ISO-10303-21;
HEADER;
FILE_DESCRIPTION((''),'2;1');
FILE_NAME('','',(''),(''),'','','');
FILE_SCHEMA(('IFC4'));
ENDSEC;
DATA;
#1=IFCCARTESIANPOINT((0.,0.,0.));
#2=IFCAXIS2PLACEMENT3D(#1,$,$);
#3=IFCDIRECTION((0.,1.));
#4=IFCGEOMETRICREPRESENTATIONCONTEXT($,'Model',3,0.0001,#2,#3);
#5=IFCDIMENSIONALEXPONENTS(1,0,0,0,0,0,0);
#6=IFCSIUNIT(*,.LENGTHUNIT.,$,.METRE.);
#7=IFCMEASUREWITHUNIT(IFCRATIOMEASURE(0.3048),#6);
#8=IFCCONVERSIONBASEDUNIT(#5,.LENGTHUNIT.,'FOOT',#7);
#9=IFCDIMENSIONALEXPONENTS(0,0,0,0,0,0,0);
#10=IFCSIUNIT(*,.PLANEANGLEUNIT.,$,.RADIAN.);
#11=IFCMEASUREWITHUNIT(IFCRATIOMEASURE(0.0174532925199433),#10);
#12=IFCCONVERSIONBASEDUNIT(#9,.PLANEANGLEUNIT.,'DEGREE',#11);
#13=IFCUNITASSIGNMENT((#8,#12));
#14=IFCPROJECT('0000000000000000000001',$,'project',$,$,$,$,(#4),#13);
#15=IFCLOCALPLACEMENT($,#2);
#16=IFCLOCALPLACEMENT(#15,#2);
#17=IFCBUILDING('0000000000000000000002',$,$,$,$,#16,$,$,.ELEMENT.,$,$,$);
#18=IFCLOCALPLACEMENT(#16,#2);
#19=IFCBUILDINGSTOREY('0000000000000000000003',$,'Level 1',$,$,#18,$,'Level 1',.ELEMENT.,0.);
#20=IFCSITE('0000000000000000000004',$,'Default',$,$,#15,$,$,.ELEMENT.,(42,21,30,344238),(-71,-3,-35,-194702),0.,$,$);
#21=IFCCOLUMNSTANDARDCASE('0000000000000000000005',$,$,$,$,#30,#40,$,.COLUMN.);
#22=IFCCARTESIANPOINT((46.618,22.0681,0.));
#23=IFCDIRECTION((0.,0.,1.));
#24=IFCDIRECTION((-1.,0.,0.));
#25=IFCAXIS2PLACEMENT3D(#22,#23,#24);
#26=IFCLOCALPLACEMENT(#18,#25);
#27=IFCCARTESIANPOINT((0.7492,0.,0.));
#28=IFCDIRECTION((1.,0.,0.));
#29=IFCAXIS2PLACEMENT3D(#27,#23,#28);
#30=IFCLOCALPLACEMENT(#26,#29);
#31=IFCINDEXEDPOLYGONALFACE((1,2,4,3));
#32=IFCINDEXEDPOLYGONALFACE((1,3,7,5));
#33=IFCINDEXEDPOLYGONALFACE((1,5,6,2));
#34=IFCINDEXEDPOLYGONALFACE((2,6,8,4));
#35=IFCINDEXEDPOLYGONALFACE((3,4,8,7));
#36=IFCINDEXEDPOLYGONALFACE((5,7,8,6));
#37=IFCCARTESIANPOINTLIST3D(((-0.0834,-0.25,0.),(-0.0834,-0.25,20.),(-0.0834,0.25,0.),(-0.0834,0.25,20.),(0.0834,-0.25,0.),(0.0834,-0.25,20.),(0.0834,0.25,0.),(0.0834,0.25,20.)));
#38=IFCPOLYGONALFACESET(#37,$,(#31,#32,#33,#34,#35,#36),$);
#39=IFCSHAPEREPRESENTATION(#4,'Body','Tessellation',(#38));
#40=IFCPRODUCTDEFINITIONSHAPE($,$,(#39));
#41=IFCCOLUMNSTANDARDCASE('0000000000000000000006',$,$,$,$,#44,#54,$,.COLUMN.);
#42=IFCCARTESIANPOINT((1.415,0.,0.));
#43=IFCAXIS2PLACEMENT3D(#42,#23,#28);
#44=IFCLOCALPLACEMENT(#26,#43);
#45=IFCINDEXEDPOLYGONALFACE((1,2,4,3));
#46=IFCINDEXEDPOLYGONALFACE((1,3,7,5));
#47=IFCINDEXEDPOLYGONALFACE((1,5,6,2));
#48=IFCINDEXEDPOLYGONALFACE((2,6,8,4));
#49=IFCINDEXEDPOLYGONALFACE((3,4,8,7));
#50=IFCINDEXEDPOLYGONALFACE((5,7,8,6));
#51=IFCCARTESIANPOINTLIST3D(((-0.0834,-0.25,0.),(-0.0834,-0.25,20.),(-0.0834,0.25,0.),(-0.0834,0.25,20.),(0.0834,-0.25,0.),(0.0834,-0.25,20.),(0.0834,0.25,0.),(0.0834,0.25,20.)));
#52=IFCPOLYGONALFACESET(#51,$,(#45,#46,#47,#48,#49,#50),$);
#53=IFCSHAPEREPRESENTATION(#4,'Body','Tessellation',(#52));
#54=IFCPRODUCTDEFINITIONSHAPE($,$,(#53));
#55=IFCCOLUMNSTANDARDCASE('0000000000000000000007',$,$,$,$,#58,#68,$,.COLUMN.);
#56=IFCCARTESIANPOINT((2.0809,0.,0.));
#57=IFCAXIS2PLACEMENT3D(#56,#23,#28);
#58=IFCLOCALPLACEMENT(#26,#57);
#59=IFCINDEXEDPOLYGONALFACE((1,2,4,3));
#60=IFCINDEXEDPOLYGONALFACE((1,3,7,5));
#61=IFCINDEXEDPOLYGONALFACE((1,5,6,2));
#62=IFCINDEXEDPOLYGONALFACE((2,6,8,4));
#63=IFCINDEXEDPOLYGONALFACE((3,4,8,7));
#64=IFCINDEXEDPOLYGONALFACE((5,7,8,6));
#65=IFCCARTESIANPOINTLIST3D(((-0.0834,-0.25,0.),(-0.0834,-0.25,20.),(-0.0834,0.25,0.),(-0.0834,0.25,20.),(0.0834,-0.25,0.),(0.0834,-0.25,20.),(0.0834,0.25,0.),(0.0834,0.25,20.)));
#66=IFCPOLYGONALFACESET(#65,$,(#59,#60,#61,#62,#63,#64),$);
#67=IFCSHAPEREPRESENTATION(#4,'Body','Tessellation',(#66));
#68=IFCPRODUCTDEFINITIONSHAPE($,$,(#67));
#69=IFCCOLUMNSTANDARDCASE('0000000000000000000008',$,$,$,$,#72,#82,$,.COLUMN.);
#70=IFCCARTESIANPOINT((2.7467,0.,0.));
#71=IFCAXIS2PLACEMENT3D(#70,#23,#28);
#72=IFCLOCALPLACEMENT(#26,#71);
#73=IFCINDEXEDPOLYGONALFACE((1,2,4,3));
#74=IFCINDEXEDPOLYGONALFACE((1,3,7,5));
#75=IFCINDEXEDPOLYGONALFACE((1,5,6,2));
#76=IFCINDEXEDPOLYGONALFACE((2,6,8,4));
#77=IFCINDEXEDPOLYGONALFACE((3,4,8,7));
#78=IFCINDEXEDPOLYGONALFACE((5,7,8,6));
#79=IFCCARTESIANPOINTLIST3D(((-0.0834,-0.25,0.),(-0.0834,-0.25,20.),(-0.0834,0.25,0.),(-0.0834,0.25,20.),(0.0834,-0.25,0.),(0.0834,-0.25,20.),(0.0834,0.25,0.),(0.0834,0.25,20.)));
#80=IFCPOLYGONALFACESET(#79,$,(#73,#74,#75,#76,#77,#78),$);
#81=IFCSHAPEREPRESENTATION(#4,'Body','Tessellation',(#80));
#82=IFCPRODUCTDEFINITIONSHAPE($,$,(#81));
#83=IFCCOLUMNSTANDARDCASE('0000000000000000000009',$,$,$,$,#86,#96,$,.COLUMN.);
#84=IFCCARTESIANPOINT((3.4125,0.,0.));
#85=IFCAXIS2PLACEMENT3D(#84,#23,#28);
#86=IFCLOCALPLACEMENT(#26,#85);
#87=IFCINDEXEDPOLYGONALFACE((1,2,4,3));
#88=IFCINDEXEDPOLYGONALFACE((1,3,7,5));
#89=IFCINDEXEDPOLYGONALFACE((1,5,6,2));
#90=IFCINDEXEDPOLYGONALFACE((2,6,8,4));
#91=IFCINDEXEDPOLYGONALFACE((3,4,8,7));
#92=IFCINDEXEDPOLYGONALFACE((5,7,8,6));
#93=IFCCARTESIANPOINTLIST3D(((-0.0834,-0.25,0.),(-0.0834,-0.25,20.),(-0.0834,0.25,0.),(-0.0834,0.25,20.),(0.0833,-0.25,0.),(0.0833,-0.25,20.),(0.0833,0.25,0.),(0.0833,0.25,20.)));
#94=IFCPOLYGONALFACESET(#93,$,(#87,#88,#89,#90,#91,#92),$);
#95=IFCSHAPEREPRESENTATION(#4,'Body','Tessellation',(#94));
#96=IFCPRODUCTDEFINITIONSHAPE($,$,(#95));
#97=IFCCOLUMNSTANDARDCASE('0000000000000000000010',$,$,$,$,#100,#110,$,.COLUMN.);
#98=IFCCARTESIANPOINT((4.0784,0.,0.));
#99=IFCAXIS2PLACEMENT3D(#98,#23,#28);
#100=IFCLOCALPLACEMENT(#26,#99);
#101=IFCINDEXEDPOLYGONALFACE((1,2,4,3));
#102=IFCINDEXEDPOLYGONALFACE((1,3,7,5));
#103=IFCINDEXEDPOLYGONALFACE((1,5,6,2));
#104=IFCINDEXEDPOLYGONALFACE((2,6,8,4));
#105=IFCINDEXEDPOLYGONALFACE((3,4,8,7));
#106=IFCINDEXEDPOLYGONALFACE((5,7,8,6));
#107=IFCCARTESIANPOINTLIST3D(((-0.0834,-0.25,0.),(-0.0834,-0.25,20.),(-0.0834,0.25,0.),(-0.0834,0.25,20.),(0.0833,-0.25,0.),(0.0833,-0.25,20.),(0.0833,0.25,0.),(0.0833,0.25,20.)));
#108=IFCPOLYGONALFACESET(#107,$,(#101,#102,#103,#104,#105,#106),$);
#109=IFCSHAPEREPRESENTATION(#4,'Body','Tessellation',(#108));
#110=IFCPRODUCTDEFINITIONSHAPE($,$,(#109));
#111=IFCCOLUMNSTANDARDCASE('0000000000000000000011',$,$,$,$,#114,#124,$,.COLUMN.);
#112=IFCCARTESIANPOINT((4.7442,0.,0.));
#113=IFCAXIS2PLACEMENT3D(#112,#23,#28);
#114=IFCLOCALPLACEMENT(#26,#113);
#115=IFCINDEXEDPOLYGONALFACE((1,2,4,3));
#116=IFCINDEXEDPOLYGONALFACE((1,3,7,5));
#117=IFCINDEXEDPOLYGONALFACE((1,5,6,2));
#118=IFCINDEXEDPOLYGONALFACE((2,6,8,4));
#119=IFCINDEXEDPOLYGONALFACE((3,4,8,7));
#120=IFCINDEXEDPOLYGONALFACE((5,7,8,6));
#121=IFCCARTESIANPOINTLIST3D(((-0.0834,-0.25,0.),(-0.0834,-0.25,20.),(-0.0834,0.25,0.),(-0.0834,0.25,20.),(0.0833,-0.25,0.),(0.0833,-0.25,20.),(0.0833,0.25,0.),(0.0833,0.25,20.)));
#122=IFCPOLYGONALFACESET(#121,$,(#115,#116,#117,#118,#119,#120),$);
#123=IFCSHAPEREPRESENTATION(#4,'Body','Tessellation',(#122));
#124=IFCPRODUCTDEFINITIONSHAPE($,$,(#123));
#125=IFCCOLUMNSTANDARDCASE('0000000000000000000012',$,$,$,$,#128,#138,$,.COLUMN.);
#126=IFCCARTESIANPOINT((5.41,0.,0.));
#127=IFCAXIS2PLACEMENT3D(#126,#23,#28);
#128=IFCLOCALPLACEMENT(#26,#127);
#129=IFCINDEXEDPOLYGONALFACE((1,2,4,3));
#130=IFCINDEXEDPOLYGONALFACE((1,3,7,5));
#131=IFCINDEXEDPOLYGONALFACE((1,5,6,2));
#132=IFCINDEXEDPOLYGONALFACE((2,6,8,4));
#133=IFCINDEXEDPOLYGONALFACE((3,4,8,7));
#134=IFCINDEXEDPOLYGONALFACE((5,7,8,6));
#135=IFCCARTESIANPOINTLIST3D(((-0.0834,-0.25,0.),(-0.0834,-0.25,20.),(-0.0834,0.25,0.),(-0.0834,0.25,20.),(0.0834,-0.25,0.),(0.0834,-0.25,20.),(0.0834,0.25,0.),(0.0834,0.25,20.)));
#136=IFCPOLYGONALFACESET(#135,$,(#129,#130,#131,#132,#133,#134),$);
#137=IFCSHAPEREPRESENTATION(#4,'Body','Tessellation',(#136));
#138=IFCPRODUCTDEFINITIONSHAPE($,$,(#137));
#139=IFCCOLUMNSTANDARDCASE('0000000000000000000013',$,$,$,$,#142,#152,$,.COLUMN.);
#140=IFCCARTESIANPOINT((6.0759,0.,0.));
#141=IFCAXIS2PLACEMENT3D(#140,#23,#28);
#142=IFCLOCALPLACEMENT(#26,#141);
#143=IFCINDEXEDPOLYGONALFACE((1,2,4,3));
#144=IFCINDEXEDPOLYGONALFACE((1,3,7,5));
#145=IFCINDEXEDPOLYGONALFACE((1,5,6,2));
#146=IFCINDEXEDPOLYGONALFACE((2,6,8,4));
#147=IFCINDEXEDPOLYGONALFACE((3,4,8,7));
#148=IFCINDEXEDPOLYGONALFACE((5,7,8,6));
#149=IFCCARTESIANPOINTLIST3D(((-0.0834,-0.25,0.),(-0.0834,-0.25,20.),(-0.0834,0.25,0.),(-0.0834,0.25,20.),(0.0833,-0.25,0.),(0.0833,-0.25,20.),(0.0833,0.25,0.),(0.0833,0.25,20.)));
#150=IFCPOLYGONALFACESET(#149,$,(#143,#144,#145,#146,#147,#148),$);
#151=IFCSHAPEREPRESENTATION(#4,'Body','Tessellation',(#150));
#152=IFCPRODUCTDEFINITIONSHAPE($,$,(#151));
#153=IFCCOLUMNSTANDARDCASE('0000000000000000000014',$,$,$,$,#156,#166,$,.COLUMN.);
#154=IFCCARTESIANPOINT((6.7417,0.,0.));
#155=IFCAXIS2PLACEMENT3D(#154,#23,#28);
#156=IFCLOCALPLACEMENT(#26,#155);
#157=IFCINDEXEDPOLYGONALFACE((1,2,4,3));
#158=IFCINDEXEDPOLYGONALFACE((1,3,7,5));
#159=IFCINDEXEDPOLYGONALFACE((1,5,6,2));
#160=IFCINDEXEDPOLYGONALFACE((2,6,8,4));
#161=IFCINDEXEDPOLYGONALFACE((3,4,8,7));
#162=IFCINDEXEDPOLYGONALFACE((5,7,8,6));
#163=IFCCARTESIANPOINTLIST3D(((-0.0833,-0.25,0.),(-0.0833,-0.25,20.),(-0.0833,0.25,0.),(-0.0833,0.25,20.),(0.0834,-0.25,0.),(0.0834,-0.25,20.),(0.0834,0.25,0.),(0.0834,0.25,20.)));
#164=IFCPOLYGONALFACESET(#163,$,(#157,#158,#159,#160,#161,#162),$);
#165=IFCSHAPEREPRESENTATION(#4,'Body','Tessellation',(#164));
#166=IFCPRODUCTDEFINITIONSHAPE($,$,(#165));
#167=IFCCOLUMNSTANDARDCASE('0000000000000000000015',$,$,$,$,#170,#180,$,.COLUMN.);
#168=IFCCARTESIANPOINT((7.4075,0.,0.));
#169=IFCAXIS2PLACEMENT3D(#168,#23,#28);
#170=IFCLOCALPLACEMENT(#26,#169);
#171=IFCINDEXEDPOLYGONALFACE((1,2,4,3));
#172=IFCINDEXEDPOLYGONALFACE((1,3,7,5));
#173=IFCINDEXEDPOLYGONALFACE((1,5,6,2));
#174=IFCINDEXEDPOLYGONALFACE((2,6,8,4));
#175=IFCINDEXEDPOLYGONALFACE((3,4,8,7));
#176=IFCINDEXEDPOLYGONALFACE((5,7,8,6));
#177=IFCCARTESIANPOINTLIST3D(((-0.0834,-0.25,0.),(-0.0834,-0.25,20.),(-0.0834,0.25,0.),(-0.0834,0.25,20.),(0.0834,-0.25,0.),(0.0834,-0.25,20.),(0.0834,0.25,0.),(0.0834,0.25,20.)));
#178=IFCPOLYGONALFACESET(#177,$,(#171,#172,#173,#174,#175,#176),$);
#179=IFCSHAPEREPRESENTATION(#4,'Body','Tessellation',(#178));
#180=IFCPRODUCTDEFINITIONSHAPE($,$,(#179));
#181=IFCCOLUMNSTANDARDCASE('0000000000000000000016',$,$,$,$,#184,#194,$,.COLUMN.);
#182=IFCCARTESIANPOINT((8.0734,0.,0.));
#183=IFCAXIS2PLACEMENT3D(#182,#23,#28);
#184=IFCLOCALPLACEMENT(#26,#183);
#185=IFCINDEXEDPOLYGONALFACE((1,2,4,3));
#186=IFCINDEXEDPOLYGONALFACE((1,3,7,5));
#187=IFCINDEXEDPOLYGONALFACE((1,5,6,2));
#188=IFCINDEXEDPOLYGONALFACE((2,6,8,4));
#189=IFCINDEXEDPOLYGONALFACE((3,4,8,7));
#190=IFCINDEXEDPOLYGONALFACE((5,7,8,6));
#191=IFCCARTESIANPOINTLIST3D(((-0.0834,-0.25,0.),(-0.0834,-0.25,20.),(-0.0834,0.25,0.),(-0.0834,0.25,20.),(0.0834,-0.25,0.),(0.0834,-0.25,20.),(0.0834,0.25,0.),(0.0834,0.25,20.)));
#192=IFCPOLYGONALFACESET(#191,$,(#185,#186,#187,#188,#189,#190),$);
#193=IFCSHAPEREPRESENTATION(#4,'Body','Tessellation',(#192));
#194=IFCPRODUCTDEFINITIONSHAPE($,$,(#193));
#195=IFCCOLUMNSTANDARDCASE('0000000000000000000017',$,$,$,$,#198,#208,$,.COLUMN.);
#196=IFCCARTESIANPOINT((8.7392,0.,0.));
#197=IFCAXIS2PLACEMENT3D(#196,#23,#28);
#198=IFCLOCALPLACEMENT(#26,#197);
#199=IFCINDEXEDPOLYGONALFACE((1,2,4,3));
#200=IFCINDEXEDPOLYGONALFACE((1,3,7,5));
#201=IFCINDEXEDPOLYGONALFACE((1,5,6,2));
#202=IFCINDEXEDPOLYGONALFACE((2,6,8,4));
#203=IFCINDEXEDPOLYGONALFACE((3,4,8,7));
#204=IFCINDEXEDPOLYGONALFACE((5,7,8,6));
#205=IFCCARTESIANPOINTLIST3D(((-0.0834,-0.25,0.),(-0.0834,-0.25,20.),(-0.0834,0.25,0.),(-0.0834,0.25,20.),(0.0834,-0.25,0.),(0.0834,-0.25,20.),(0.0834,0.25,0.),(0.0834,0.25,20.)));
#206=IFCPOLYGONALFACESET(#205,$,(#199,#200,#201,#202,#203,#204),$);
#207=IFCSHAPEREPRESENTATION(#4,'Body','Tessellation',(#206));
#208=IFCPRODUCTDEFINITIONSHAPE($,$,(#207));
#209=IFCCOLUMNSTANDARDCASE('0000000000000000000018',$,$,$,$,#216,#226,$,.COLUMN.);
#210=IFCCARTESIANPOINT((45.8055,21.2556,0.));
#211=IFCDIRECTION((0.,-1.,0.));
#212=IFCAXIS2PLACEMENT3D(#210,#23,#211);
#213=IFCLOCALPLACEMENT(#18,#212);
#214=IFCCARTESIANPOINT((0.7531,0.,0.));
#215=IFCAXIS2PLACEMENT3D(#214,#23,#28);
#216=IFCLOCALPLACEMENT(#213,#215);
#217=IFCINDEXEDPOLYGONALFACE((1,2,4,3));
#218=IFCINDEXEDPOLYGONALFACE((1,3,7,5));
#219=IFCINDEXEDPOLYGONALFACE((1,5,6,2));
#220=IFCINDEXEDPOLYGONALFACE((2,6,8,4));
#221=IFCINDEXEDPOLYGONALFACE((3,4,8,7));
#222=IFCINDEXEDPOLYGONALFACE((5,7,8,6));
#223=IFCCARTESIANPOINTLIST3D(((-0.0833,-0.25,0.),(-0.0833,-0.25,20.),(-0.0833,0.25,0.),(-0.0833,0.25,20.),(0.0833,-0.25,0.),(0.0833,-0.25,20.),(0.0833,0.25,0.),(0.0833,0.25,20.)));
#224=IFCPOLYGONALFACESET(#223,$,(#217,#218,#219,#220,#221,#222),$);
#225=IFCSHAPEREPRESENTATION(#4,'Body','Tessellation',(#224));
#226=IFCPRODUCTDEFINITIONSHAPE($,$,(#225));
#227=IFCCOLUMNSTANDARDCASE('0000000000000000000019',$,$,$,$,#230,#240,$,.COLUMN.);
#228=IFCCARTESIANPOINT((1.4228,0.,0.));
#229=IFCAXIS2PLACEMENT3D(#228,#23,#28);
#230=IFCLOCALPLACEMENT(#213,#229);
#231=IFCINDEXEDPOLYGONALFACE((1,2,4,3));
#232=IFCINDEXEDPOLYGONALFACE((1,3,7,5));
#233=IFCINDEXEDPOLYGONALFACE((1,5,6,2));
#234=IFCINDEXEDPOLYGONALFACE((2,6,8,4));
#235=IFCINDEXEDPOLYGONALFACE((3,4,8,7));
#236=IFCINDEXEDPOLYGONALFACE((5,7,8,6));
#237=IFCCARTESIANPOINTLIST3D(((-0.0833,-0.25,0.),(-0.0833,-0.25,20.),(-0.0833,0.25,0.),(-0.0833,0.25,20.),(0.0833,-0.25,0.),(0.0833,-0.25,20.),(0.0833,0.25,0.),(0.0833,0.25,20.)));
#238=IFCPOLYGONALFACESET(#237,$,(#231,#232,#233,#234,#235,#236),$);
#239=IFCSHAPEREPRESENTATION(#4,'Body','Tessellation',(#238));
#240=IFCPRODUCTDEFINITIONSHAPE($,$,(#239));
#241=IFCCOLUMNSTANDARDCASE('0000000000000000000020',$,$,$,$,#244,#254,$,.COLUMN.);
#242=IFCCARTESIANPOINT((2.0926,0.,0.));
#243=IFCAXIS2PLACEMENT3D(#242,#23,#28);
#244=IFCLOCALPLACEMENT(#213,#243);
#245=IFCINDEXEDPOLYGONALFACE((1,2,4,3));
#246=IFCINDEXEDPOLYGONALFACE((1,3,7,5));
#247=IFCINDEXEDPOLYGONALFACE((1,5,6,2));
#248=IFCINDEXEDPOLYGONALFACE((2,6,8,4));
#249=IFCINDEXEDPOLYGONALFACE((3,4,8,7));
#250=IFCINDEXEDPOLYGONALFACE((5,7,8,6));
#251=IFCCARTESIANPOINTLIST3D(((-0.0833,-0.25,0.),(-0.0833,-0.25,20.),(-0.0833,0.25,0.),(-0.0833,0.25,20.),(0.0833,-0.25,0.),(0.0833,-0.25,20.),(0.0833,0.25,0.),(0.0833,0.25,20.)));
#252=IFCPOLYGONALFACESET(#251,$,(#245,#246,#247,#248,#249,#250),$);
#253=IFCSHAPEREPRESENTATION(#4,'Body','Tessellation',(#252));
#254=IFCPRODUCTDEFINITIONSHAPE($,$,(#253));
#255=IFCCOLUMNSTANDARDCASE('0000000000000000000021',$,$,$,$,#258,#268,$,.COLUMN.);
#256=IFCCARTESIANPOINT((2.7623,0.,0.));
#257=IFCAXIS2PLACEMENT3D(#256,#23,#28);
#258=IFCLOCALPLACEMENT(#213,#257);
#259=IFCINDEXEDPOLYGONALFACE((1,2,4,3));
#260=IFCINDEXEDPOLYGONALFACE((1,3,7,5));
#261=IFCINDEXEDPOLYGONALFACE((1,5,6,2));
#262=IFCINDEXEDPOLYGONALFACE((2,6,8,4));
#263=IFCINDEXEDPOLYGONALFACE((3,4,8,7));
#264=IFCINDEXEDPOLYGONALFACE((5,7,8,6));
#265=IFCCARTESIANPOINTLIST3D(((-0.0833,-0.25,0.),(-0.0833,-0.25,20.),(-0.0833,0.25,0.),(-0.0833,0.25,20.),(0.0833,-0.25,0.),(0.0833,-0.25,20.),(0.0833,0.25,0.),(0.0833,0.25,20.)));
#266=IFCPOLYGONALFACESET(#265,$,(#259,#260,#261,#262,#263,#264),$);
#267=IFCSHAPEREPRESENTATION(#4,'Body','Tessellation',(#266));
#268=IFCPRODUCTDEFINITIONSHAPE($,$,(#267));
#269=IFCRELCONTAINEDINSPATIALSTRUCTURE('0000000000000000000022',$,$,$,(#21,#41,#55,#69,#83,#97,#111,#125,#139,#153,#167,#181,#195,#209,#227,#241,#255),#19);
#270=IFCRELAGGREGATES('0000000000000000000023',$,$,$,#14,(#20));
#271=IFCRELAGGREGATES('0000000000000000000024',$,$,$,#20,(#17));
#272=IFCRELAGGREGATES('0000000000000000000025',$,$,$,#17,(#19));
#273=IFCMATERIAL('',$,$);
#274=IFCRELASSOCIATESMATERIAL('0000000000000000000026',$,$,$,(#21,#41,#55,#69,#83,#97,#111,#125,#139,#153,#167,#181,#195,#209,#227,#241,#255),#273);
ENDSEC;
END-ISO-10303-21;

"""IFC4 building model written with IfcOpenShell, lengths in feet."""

from ifc_helpers import new_model, entity, si_unit, converted_unit, direction, frame, origin, place, context, project, spatial, rectangle, extrude, material, element, save


model = new_model("IFC4")

# Units and contexts
model_context = context("Model", 3, precision=0.0001, world=origin(), true_north=direction((0.0, 1.0)))
ifc_project = project(units=[converted_unit("LENGTHUNIT", "FOOT", entity("IfcRatioMeasure", 0.3048), si_unit("LENGTHUNIT", "METRE"), dimensions=[1, 0, 0, 0, 0, 0, 0]), converted_unit("PLANEANGLEUNIT", "DEGREE", entity("IfcRatioMeasure", 0.0174532925199433), si_unit("PLANEANGLEUNIT", "RADIAN"), dimensions=[0, 0, 0, 0, 0, 0, 0])], contexts=[model_context])

# Site, building, storey
site_placement = place(None, origin())
site = spatial("IfcSite", under=ifc_project, at=site_placement, Name="Default", CompositionType="ELEMENT", RefLatitude=(42, 21, 30, 344238), RefLongitude=(-71, -3, -35, -194702), RefElevation=0.0)
building_placement = place(site_placement, origin())
building = spatial("IfcBuilding", under=site, at=building_placement, CompositionType="ELEMENT")
storey_placement = place(building_placement, origin())
storey = spatial("IfcBuildingStorey", under=building, at=storey_placement, Name="Level 1", LongName="Level 1", CompositionType="ELEMENT", Elevation=0.0)

# Columns
ifc_material_1 = material(Name="")
wall_1_placement = place(storey_placement, frame((46.618, 22.0681, 0.0), z_axis=(0.0, 0.0, 1.0), x_axis=(-1.0, 0.0, 0.0)))
for number, where, z_axis, x_axis in (
    (1, (0.7492, 0.0, 0.0), (0.0, 0.0, 1.0), (1.0, 0.0, 0.0)),
    (2, (1.415, 0.0, 0.0), (0.0, 0.0, 1.0), (1.0, 0.0, 0.0)),
    (3, (2.0809, 0.0, 0.0), (0.0, 0.0, 1.0), (1.0, 0.0, 0.0)),
    (4, (2.7467, 0.0, 0.0), (0.0, 0.0, 1.0), (1.0, 0.0, 0.0)),
    (5, (3.4125, 0.0, 0.0), (0.0, 0.0, 1.0), (1.0, 0.0, 0.0)),
    (6, (4.0784, 0.0, 0.0), (0.0, 0.0, 1.0), (1.0, 0.0, 0.0)),
    (7, (4.7442, 0.0, 0.0), (0.0, 0.0, 1.0), (1.0, 0.0, 0.0)),
    (8, (5.41, 0.0, 0.0), (0.0, 0.0, 1.0), (1.0, 0.0, 0.0)),
    (9, (6.0759, 0.0, 0.0), (0.0, 0.0, 1.0), (1.0, 0.0, 0.0)),
    (10, (6.7417, 0.0, 0.0), (0.0, 0.0, 1.0), (1.0, 0.0, 0.0)),
    (11, (7.4075, 0.0, 0.0), (0.0, 0.0, 1.0), (1.0, 0.0, 0.0)),
    (12, (8.0734, 0.0, 0.0), (0.0, 0.0, 1.0), (1.0, 0.0, 0.0)),
    (13, (8.7392, 0.0, 0.0), (0.0, 0.0, 1.0), (1.0, 0.0, 0.0)),
):
    element("IfcColumnStandardCase", number, at=place(wall_1_placement, frame(where, z_axis=z_axis, x_axis=x_axis)), inside=storey, material=ifc_material_1, PredefinedType="COLUMN", context=model_context, shape_type="SweptSolid", body=[
        extrude(rectangle(XDim=0.1667, YDim=0.5), origin(), (0.0, 0.0, 1.0), 20.0),
    ])
wall_2_placement = place(storey_placement, frame((45.8055, 21.2556, 0.0), z_axis=(0.0, 0.0, 1.0), x_axis=(0.0, -1.0, 0.0)))
for number, where, z_axis, x_axis in (
    (14, (0.7531, 0.0, 0.0), (0.0, 0.0, 1.0), (1.0, 0.0, 0.0)),
    (15, (1.4228, 0.0, 0.0), (0.0, 0.0, 1.0), (1.0, 0.0, 0.0)),
    (16, (2.0926, 0.0, 0.0), (0.0, 0.0, 1.0), (1.0, 0.0, 0.0)),
    (17, (2.7623, 0.0, 0.0), (0.0, 0.0, 1.0), (1.0, 0.0, 0.0)),
):
    element("IfcColumnStandardCase", number, at=place(wall_2_placement, frame(where, z_axis=z_axis, x_axis=x_axis)), inside=storey, material=ifc_material_1, PredefinedType="COLUMN", context=model_context, shape_type="SweptSolid", body=[
        extrude(rectangle(XDim=0.1667, YDim=0.5), origin(), (0.0, 0.0, 1.0), 20.0),
    ])

save(model, "model.ifc")
